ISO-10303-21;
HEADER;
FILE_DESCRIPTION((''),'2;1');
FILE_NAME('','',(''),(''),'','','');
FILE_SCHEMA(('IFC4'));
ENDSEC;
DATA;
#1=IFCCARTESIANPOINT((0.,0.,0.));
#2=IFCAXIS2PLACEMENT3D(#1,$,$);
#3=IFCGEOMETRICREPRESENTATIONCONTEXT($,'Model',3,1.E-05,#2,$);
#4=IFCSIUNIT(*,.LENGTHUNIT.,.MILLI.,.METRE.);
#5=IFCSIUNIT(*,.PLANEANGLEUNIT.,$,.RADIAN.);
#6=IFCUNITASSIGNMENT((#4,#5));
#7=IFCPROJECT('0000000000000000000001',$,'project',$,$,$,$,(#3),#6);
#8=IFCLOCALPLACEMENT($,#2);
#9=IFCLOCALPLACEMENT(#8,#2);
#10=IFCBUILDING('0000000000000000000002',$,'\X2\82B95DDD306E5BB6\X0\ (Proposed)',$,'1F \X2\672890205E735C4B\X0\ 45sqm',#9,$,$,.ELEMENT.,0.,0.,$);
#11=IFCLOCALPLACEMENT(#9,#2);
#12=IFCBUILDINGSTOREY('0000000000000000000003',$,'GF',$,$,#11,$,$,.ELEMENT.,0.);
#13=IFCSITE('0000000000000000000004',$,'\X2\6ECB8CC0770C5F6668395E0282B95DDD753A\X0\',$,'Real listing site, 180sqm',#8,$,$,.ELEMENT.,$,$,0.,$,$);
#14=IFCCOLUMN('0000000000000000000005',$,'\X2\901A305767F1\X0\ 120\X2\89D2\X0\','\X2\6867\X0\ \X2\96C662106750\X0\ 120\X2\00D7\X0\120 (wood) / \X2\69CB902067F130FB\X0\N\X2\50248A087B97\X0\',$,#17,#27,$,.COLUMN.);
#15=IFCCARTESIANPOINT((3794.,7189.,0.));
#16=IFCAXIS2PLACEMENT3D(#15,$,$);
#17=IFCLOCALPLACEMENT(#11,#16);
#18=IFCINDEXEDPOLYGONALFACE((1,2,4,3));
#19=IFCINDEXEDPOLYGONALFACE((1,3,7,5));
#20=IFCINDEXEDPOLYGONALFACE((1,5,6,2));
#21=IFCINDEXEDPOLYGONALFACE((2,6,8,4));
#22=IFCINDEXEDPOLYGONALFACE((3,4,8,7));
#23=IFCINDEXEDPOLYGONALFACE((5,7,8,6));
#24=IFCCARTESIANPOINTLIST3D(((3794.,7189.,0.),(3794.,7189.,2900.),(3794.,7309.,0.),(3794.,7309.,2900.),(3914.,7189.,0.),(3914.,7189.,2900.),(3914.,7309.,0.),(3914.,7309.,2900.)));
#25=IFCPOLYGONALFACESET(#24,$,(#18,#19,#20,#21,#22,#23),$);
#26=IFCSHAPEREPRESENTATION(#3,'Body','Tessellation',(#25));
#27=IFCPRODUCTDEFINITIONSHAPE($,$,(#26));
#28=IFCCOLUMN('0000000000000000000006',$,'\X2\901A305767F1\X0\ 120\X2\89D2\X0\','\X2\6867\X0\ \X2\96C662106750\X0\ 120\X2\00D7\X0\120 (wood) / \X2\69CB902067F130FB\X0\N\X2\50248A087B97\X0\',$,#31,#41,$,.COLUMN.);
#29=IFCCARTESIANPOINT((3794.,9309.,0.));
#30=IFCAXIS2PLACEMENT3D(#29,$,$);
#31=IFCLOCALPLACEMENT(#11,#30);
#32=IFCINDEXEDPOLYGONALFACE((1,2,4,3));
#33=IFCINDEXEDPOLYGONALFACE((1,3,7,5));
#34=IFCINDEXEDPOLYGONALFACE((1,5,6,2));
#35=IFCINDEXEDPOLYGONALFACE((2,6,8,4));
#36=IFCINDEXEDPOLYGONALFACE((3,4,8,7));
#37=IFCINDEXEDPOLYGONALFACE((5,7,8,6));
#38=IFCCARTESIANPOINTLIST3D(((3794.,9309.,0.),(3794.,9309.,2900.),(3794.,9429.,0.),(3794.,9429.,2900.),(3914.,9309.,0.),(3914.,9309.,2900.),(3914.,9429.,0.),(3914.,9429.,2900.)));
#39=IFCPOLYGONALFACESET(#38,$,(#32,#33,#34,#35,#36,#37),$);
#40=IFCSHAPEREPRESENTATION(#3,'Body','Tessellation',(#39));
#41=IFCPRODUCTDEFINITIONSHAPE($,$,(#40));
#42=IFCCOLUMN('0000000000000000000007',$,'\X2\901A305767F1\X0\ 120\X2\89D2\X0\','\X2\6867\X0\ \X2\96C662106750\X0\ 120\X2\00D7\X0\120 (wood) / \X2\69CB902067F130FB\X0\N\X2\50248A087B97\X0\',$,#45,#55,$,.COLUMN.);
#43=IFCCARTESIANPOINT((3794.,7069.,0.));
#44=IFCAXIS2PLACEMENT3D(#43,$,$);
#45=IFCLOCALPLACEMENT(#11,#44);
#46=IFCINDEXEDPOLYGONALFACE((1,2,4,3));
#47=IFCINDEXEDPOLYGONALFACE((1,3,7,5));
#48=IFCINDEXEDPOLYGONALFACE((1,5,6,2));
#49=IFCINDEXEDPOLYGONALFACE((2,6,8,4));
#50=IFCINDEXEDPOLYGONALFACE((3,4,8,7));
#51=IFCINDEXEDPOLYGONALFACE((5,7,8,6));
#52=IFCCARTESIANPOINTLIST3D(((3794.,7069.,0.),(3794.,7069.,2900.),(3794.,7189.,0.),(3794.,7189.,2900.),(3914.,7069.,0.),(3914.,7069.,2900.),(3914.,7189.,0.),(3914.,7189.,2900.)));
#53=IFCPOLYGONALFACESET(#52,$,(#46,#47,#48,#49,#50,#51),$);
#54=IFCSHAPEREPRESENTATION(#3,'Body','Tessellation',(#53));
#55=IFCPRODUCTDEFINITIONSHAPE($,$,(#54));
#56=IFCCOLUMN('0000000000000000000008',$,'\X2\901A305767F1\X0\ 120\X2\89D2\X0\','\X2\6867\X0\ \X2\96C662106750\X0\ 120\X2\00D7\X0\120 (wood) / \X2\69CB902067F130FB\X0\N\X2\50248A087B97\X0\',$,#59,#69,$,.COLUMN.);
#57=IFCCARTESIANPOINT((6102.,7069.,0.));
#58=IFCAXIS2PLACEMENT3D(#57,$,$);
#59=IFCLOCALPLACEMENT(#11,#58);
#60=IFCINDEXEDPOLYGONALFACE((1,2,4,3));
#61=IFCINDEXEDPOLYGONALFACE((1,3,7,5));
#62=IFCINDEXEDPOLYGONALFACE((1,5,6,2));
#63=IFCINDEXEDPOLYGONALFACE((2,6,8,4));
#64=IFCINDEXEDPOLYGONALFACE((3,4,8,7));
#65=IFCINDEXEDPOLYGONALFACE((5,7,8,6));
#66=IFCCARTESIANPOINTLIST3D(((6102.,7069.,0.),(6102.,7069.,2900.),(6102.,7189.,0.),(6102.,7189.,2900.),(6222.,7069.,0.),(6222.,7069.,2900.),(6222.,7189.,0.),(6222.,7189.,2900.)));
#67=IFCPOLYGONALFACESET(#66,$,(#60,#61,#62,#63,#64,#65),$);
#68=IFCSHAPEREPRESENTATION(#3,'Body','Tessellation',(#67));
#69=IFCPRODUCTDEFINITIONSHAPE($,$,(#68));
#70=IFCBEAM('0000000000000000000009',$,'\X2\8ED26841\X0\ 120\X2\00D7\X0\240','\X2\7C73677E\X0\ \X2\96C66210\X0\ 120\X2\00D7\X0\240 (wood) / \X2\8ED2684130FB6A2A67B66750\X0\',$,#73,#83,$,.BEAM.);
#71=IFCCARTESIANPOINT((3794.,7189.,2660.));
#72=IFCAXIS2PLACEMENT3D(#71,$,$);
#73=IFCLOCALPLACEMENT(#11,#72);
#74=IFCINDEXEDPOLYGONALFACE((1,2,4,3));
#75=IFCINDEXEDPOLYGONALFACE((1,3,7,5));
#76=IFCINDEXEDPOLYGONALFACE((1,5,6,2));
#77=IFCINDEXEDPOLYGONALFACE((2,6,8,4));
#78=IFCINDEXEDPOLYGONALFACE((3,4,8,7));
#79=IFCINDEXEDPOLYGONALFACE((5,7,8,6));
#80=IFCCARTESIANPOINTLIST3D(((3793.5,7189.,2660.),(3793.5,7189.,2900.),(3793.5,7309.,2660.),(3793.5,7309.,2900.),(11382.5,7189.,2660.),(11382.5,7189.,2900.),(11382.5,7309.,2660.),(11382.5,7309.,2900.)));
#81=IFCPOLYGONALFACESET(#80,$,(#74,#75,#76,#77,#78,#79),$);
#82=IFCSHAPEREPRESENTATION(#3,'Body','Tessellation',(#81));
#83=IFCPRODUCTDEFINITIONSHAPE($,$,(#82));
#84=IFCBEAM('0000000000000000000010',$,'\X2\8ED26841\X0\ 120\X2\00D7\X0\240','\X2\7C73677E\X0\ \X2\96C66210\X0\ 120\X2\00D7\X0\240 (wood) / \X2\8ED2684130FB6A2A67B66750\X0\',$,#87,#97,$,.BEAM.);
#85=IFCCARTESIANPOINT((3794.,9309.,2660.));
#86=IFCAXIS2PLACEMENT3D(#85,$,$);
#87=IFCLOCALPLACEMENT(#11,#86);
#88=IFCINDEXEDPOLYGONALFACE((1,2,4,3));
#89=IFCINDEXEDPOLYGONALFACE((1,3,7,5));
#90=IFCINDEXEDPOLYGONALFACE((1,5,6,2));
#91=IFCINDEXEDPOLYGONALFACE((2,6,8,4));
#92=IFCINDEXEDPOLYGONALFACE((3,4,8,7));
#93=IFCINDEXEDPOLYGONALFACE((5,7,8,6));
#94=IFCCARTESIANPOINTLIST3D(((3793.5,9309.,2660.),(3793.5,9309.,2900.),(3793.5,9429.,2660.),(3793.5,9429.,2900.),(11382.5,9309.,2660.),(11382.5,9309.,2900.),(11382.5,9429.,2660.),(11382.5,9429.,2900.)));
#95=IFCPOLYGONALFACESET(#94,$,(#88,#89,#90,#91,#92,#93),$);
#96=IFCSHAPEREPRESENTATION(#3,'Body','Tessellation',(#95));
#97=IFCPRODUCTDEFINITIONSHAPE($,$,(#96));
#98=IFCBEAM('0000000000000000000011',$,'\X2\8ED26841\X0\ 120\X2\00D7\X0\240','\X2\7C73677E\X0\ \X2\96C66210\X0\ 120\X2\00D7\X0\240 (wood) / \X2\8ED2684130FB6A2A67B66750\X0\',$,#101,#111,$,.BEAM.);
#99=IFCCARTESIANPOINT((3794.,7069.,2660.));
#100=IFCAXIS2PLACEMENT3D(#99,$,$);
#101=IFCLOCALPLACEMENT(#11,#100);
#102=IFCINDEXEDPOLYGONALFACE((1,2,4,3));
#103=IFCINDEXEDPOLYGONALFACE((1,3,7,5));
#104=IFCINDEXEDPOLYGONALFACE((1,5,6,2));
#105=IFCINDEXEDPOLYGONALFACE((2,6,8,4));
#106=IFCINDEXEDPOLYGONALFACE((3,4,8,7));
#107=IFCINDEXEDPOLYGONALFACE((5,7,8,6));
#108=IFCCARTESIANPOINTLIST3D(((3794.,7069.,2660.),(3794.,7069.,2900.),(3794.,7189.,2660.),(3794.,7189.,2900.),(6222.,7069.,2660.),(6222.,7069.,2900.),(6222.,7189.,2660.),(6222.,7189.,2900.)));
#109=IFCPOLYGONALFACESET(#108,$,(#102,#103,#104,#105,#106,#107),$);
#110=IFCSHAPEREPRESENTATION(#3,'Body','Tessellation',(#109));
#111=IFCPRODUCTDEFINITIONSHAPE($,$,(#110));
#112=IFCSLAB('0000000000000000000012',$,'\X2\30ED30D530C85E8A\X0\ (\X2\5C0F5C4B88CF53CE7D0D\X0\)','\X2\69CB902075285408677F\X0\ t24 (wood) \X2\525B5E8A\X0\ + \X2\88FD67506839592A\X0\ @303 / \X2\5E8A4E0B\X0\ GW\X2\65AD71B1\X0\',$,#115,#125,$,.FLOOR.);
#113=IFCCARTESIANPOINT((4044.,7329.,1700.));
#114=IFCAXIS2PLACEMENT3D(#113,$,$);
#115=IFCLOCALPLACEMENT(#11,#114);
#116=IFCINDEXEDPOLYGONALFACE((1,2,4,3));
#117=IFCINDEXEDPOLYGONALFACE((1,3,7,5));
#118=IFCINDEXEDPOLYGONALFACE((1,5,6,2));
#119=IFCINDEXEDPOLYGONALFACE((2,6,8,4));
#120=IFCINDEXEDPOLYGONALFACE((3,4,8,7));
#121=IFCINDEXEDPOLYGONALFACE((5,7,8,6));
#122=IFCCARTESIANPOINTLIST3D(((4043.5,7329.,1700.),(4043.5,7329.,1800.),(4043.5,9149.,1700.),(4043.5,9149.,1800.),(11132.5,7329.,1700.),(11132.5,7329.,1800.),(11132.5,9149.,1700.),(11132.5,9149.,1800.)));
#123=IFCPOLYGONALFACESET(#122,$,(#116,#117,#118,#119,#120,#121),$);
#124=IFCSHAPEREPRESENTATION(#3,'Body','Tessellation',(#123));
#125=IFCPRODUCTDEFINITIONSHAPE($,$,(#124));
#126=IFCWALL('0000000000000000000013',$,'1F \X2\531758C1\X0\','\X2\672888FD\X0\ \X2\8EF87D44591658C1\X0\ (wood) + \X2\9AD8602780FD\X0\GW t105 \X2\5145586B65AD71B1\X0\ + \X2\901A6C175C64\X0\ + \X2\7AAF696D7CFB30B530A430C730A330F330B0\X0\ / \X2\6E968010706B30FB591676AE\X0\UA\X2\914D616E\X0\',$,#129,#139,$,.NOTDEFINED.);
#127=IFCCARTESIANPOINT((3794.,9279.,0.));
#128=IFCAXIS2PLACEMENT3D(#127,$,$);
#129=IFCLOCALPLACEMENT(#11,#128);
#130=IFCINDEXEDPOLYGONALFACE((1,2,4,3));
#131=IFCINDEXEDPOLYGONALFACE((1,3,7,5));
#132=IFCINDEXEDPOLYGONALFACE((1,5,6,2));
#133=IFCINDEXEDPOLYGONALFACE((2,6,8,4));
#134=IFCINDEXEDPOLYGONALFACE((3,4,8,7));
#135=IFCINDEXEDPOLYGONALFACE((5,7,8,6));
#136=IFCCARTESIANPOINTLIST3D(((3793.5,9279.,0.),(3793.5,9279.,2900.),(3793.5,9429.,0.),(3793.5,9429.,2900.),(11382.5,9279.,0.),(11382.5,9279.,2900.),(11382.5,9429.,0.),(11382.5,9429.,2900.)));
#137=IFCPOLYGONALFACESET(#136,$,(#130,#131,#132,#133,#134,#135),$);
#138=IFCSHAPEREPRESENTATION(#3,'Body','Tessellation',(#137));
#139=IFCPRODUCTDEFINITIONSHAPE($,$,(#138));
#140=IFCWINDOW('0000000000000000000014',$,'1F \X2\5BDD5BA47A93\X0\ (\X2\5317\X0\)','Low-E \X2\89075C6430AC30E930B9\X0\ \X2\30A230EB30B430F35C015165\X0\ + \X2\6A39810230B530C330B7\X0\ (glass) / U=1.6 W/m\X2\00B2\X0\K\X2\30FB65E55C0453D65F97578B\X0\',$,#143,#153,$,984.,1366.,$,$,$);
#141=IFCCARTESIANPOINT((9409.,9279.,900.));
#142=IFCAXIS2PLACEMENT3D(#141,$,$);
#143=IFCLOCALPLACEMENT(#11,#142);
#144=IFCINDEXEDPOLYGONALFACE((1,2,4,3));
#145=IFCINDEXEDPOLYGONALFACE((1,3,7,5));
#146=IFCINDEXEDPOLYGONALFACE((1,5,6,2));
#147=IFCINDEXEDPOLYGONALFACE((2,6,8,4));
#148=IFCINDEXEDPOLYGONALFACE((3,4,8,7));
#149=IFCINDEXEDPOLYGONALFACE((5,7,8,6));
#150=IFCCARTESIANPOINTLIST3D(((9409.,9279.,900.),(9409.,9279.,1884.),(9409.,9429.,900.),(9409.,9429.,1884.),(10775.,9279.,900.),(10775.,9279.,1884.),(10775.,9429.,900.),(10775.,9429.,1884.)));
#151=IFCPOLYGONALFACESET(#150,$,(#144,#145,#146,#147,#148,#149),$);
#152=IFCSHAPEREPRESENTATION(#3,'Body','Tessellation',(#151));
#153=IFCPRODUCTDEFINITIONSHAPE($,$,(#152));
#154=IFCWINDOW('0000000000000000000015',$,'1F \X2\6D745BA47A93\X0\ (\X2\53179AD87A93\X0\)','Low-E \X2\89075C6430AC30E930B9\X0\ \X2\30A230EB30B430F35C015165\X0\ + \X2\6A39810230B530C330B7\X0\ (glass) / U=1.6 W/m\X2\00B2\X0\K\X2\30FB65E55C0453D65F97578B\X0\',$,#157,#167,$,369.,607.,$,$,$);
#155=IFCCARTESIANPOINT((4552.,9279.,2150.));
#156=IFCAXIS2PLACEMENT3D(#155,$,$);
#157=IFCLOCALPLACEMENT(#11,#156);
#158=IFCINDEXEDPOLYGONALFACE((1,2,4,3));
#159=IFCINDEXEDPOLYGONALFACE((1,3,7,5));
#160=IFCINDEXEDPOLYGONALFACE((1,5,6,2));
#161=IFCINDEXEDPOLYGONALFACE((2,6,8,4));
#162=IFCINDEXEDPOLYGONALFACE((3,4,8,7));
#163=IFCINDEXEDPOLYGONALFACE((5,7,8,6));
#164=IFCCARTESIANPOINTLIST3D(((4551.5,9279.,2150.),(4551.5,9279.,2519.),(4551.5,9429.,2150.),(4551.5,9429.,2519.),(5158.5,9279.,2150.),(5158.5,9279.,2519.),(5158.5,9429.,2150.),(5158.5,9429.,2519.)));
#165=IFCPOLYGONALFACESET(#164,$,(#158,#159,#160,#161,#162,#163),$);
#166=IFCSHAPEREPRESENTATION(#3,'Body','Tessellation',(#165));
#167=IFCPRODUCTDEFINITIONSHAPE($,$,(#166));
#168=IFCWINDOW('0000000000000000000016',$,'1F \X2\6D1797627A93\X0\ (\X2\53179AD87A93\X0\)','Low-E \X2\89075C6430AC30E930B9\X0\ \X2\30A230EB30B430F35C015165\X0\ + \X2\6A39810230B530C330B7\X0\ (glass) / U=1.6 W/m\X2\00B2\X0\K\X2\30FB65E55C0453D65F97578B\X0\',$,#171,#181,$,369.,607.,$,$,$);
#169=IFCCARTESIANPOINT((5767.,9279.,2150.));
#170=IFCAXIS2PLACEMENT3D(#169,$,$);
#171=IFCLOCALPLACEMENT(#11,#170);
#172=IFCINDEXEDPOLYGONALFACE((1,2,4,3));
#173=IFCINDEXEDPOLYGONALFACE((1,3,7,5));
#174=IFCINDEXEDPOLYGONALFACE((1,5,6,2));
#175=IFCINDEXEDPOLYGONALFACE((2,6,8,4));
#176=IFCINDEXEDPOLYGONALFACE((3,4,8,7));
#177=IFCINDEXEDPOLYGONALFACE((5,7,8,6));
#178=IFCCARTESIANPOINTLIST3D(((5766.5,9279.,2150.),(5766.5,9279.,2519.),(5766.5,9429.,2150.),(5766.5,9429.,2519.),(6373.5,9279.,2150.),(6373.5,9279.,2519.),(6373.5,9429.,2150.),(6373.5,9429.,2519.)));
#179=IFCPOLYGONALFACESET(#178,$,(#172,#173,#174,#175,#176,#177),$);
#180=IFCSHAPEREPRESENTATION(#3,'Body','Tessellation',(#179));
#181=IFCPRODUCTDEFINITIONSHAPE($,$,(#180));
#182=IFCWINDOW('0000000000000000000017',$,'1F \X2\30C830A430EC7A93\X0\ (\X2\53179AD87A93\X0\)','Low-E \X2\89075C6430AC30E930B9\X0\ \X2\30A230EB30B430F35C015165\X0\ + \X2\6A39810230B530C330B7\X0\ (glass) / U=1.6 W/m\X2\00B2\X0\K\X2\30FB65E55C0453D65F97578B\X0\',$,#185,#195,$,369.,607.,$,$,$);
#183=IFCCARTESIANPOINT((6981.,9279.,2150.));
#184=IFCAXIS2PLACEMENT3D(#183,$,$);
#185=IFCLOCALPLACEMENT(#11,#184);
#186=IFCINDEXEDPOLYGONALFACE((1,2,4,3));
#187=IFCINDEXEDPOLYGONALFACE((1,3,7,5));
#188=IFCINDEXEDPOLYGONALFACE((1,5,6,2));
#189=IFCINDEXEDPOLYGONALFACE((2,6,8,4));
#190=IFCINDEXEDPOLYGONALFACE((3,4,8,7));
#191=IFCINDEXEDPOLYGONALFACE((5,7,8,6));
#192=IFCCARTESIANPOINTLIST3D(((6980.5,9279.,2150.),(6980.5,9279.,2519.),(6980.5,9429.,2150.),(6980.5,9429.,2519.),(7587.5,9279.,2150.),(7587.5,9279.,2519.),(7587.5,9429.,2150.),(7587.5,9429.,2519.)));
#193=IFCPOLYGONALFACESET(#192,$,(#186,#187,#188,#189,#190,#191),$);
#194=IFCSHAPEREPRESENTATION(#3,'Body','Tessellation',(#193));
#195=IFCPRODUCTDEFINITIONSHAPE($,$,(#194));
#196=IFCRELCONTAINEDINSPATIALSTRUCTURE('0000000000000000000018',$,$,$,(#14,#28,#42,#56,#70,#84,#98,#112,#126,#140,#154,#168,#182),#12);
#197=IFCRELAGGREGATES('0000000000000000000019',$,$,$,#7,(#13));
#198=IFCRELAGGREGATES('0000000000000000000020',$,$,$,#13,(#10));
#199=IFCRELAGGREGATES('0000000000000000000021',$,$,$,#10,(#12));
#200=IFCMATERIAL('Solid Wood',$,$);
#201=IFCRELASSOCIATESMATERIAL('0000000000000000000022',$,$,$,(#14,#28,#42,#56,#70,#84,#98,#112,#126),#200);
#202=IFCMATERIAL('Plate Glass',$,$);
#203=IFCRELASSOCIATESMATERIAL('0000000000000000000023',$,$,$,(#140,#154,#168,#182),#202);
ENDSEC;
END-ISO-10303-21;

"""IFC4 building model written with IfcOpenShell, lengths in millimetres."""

from ifc_helpers import new_model, si_unit, frame, frame_2d, origin, place, context, project, spatial, rectangle, extrude, material, element, fill, save


model = new_model("IFC4")

# Units and contexts
model_context = context("Model", 3, precision=1e-05, world=origin())
ifc_project = project(units=[si_unit("LENGTHUNIT", "METRE", prefix="MILLI"), si_unit("PLANEANGLEUNIT", "RADIAN")], contexts=[model_context])

# Site, building, storey
site_placement = place(None, origin())
site = spatial("IfcSite", under=ifc_project, at=site_placement, Name="滋賀県彦根市芹川町", ObjectType="Real listing site, 180sqm", CompositionType="ELEMENT", RefElevation=0.0)
building_placement = place(site_placement, origin())
building = spatial("IfcBuilding", under=site, at=building_placement, Name="芹川の家 (Proposed)", ObjectType="1F 木造平屋 45sqm", CompositionType="ELEMENT", ElevationOfRefHeight=0.0, ElevationOfTerrain=0.0)
storey_placement = place(building_placement, origin())
storey = spatial("IfcBuildingStorey", under=building, at=storey_placement, Name="GF", CompositionType="ELEMENT", Elevation=0.0)

# Columns
ifc_material_1 = material(Name="Solid Wood")
column_1_placement = place(storey_placement, frame((3794.0, 7189.0, 0.0)))
element("IfcColumn", 1, at=column_1_placement, inside=storey, material=ifc_material_1, Name="通し柱 120角", Description="桧 集成材 120×120 (wood) / 構造柱・N値計算", PredefinedType="COLUMN", context=model_context, shape_type="SweptSolid", body=[
    extrude(rectangle(XDim=120.0, YDim=120.0, at=frame_2d((60.0, 60.0))), frame((3794.0, 7189.0, 0.0)), (0.0, 0.0, 1.0), 2900.0),
])
column_2_placement = place(storey_placement, frame((3794.0, 9309.0, 0.0)))
element("IfcColumn", 2, at=column_2_placement, inside=storey, material=ifc_material_1, Name="通し柱 120角", Description="桧 集成材 120×120 (wood) / 構造柱・N値計算", PredefinedType="COLUMN", context=model_context, shape_type="SweptSolid", body=[
    extrude(rectangle(XDim=120.0, YDim=120.0, at=frame_2d((60.0, 60.0))), frame((3794.0, 9309.0, 0.0)), (0.0, 0.0, 1.0), 2900.0),
])
column_3_placement = place(storey_placement, frame((3794.0, 7069.0, 0.0)))
element("IfcColumn", 3, at=column_3_placement, inside=storey, material=ifc_material_1, Name="通し柱 120角", Description="桧 集成材 120×120 (wood) / 構造柱・N値計算", PredefinedType="COLUMN", context=model_context, shape_type="SweptSolid", body=[
    extrude(rectangle(XDim=120.0, YDim=120.0, at=frame_2d((60.0, 60.0))), frame((3794.0, 7069.0, 0.0)), (0.0, 0.0, 1.0), 2900.0),
])
column_4_placement = place(storey_placement, frame((6102.0, 7069.0, 0.0)))
element("IfcColumn", 4, at=column_4_placement, inside=storey, material=ifc_material_1, Name="通し柱 120角", Description="桧 集成材 120×120 (wood) / 構造柱・N値計算", PredefinedType="COLUMN", context=model_context, shape_type="SweptSolid", body=[
    extrude(rectangle(XDim=120.0, YDim=120.0, at=frame_2d((60.0, 60.0))), frame((6102.0, 7069.0, 0.0)), (0.0, 0.0, 1.0), 2900.0),
])

# Beams
beam_1_placement = place(storey_placement, frame((3794.0, 7189.0, 2660.0)))
element("IfcBeam", 5, at=beam_1_placement, inside=storey, material=ifc_material_1, Name="軒桁 120×240", Description="米松 集成 120×240 (wood) / 軒桁・横架材", PredefinedType="BEAM", context=model_context, shape_type="SweptSolid", body=[
    extrude(rectangle(XDim=7589.0, YDim=120.0, at=frame_2d((3794.0, 60.0))), frame((3794.0, 7189.0, 2660.0)), (0.0, 0.0, 1.0), 240.0),
])
beam_2_placement = place(storey_placement, frame((3794.0, 9309.0, 2660.0)))
element("IfcBeam", 6, at=beam_2_placement, inside=storey, material=ifc_material_1, Name="軒桁 120×240", Description="米松 集成 120×240 (wood) / 軒桁・横架材", PredefinedType="BEAM", context=model_context, shape_type="SweptSolid", body=[
    extrude(rectangle(XDim=7589.0, YDim=120.0, at=frame_2d((3794.0, 60.0))), frame((3794.0, 9309.0, 2660.0)), (0.0, 0.0, 1.0), 240.0),
])
beam_3_placement = place(storey_placement, frame((3794.0, 7069.0, 2660.0)))
element("IfcBeam", 7, at=beam_3_placement, inside=storey, material=ifc_material_1, Name="軒桁 120×240", Description="米松 集成 120×240 (wood) / 軒桁・横架材", PredefinedType="BEAM", context=model_context, shape_type="SweptSolid", body=[
    extrude(rectangle(XDim=2428.0, YDim=120.0, at=frame_2d((1214.0, 60.0))), frame((3794.0, 7069.0, 2660.0)), (0.0, 0.0, 1.0), 240.0),
])

# Slab
slab_1_placement = place(storey_placement, frame((4044.0, 7329.0, 1700.0)))
element("IfcSlab", 8, at=slab_1_placement, inside=storey, material=ifc_material_1, Name="ロフト床 (小屋裏収納)", Description="構造用合板 t24 (wood) 剛床 + 製材根太 @303 / 床下 GW断熱", PredefinedType="FLOOR", context=model_context, shape_type="SweptSolid", body=[
    extrude(rectangle(XDim=7089.0, YDim=1820.0, at=frame_2d((3544.0, 910.0))), frame((4044.0, 7329.0, 1700.0)), (0.0, 0.0, 1.0), 100.0),
])

# Wall, openings, windows
wall_1_placement = place(storey_placement, frame((3794.0, 9279.0, 0.0)))
wall_1 = element("IfcWall", 9, at=wall_1_placement, inside=storey, material=ifc_material_1, Name="1F 北壁", Description="木製 軸組外壁 (wood) + 高性能GW t105 充填断熱 + 通気層 + 窯業系サイディング / 準耐火・外皮UA配慮", PredefinedType="NOTDEFINED", context=model_context, shape_type="SweptSolid", body=[
    extrude(rectangle(XDim=7589.0, YDim=150.0, at=frame_2d((3794.0, 75.0))), frame((3794.0, 9279.0, 0.0)), (0.0, 0.0, 1.0), 2900.0),
])
opening_1_placement = place(storey_placement, frame((9409.0, 9279.0, 900.0)))
opening_1 = element("IfcOpeningElement", 10, at=opening_1_placement, cuts=wall_1, PredefinedType="NOTDEFINED", context=model_context, shape_type="SweptSolid", body=[
    extrude(rectangle(XDim=1366.0, YDim=150.0, at=frame_2d((683.0, 75.0))), frame((9409.0, 9279.0, 900.0)), (0.0, 0.0, 1.0), 984.0),
])
opening_2_placement = place(storey_placement, frame((4552.0, 9279.0, 2150.0)))
opening_2 = element("IfcOpeningElement", 11, at=opening_2_placement, cuts=wall_1, PredefinedType="NOTDEFINED", context=model_context, shape_type="SweptSolid", body=[
    extrude(rectangle(XDim=607.0, YDim=150.0, at=frame_2d((303.0, 75.0))), frame((4552.0, 9279.0, 2150.0)), (0.0, 0.0, 1.0), 369.0),
])
opening_3_placement = place(storey_placement, frame((5767.0, 9279.0, 2150.0)))
opening_3 = element("IfcOpeningElement", 12, at=opening_3_placement, cuts=wall_1, PredefinedType="NOTDEFINED", context=model_context, shape_type="SweptSolid", body=[
    extrude(rectangle(XDim=607.0, YDim=150.0, at=frame_2d((303.0, 75.0))), frame((5767.0, 9279.0, 2150.0)), (0.0, 0.0, 1.0), 369.0),
])
opening_4_placement = place(storey_placement, frame((6981.0, 9279.0, 2150.0)))
opening_4 = element("IfcOpeningElement", 13, at=opening_4_placement, cuts=wall_1, PredefinedType="NOTDEFINED", context=model_context, shape_type="SweptSolid", body=[
    extrude(rectangle(XDim=607.0, YDim=150.0, at=frame_2d((303.0, 75.0))), frame((6981.0, 9279.0, 2150.0)), (0.0, 0.0, 1.0), 369.0),
])
ifc_material_2 = material(Name="Plate Glass")
window_1_placement = place(storey_placement, frame((9409.0, 9279.0, 900.0)))
window_1 = element("IfcWindow", 14, at=window_1_placement, inside=storey, material=ifc_material_2, Name="1F 寝室窓 (北)", Description="Low-E 複層ガラス アルゴン封入 + 樹脂サッシ (glass) / U=1.6 W/m²K・日射取得型", OverallHeight=984.0, OverallWidth=1366.0, context=model_context, shape_type="SweptSolid", body=[
    extrude(rectangle(XDim=1366.0, YDim=150.0, at=frame_2d((683.0, 75.0))), frame((9409.0, 9279.0, 900.0)), (0.0, 0.0, 1.0), 984.0),
])
fill(opening_1, window_1)
window_2_placement = place(storey_placement, frame((4552.0, 9279.0, 2150.0)))
window_2 = element("IfcWindow", 15, at=window_2_placement, inside=storey, material=ifc_material_2, Name="1F 浴室窓 (北高窓)", Description="Low-E 複層ガラス アルゴン封入 + 樹脂サッシ (glass) / U=1.6 W/m²K・日射取得型", OverallHeight=369.0, OverallWidth=607.0, context=model_context, shape_type="SweptSolid", body=[
    extrude(rectangle(XDim=607.0, YDim=150.0, at=frame_2d((303.0, 75.0))), frame((4552.0, 9279.0, 2150.0)), (0.0, 0.0, 1.0), 369.0),
])
fill(opening_2, window_2)
window_3_placement = place(storey_placement, frame((5767.0, 9279.0, 2150.0)))
window_3 = element("IfcWindow", 16, at=window_3_placement, inside=storey, material=ifc_material_2, Name="1F 洗面窓 (北高窓)", Description="Low-E 複層ガラス アルゴン封入 + 樹脂サッシ (glass) / U=1.6 W/m²K・日射取得型", OverallHeight=369.0, OverallWidth=607.0, context=model_context, shape_type="SweptSolid", body=[
    extrude(rectangle(XDim=607.0, YDim=150.0, at=frame_2d((303.0, 75.0))), frame((5767.0, 9279.0, 2150.0)), (0.0, 0.0, 1.0), 369.0),
])
fill(opening_3, window_3)
window_4_placement = place(storey_placement, frame((6981.0, 9279.0, 2150.0)))
window_4 = element("IfcWindow", 17, at=window_4_placement, inside=storey, material=ifc_material_2, Name="1F トイレ窓 (北高窓)", Description="Low-E 複層ガラス アルゴン封入 + 樹脂サッシ (glass) / U=1.6 W/m²K・日射取得型", OverallHeight=369.0, OverallWidth=607.0, context=model_context, shape_type="SweptSolid", body=[
    extrude(rectangle(XDim=607.0, YDim=150.0, at=frame_2d((303.0, 75.0))), frame((6981.0, 9279.0, 2150.0)), (0.0, 0.0, 1.0), 369.0),
])
fill(opening_4, window_4)

save(model, "model.ifc")
